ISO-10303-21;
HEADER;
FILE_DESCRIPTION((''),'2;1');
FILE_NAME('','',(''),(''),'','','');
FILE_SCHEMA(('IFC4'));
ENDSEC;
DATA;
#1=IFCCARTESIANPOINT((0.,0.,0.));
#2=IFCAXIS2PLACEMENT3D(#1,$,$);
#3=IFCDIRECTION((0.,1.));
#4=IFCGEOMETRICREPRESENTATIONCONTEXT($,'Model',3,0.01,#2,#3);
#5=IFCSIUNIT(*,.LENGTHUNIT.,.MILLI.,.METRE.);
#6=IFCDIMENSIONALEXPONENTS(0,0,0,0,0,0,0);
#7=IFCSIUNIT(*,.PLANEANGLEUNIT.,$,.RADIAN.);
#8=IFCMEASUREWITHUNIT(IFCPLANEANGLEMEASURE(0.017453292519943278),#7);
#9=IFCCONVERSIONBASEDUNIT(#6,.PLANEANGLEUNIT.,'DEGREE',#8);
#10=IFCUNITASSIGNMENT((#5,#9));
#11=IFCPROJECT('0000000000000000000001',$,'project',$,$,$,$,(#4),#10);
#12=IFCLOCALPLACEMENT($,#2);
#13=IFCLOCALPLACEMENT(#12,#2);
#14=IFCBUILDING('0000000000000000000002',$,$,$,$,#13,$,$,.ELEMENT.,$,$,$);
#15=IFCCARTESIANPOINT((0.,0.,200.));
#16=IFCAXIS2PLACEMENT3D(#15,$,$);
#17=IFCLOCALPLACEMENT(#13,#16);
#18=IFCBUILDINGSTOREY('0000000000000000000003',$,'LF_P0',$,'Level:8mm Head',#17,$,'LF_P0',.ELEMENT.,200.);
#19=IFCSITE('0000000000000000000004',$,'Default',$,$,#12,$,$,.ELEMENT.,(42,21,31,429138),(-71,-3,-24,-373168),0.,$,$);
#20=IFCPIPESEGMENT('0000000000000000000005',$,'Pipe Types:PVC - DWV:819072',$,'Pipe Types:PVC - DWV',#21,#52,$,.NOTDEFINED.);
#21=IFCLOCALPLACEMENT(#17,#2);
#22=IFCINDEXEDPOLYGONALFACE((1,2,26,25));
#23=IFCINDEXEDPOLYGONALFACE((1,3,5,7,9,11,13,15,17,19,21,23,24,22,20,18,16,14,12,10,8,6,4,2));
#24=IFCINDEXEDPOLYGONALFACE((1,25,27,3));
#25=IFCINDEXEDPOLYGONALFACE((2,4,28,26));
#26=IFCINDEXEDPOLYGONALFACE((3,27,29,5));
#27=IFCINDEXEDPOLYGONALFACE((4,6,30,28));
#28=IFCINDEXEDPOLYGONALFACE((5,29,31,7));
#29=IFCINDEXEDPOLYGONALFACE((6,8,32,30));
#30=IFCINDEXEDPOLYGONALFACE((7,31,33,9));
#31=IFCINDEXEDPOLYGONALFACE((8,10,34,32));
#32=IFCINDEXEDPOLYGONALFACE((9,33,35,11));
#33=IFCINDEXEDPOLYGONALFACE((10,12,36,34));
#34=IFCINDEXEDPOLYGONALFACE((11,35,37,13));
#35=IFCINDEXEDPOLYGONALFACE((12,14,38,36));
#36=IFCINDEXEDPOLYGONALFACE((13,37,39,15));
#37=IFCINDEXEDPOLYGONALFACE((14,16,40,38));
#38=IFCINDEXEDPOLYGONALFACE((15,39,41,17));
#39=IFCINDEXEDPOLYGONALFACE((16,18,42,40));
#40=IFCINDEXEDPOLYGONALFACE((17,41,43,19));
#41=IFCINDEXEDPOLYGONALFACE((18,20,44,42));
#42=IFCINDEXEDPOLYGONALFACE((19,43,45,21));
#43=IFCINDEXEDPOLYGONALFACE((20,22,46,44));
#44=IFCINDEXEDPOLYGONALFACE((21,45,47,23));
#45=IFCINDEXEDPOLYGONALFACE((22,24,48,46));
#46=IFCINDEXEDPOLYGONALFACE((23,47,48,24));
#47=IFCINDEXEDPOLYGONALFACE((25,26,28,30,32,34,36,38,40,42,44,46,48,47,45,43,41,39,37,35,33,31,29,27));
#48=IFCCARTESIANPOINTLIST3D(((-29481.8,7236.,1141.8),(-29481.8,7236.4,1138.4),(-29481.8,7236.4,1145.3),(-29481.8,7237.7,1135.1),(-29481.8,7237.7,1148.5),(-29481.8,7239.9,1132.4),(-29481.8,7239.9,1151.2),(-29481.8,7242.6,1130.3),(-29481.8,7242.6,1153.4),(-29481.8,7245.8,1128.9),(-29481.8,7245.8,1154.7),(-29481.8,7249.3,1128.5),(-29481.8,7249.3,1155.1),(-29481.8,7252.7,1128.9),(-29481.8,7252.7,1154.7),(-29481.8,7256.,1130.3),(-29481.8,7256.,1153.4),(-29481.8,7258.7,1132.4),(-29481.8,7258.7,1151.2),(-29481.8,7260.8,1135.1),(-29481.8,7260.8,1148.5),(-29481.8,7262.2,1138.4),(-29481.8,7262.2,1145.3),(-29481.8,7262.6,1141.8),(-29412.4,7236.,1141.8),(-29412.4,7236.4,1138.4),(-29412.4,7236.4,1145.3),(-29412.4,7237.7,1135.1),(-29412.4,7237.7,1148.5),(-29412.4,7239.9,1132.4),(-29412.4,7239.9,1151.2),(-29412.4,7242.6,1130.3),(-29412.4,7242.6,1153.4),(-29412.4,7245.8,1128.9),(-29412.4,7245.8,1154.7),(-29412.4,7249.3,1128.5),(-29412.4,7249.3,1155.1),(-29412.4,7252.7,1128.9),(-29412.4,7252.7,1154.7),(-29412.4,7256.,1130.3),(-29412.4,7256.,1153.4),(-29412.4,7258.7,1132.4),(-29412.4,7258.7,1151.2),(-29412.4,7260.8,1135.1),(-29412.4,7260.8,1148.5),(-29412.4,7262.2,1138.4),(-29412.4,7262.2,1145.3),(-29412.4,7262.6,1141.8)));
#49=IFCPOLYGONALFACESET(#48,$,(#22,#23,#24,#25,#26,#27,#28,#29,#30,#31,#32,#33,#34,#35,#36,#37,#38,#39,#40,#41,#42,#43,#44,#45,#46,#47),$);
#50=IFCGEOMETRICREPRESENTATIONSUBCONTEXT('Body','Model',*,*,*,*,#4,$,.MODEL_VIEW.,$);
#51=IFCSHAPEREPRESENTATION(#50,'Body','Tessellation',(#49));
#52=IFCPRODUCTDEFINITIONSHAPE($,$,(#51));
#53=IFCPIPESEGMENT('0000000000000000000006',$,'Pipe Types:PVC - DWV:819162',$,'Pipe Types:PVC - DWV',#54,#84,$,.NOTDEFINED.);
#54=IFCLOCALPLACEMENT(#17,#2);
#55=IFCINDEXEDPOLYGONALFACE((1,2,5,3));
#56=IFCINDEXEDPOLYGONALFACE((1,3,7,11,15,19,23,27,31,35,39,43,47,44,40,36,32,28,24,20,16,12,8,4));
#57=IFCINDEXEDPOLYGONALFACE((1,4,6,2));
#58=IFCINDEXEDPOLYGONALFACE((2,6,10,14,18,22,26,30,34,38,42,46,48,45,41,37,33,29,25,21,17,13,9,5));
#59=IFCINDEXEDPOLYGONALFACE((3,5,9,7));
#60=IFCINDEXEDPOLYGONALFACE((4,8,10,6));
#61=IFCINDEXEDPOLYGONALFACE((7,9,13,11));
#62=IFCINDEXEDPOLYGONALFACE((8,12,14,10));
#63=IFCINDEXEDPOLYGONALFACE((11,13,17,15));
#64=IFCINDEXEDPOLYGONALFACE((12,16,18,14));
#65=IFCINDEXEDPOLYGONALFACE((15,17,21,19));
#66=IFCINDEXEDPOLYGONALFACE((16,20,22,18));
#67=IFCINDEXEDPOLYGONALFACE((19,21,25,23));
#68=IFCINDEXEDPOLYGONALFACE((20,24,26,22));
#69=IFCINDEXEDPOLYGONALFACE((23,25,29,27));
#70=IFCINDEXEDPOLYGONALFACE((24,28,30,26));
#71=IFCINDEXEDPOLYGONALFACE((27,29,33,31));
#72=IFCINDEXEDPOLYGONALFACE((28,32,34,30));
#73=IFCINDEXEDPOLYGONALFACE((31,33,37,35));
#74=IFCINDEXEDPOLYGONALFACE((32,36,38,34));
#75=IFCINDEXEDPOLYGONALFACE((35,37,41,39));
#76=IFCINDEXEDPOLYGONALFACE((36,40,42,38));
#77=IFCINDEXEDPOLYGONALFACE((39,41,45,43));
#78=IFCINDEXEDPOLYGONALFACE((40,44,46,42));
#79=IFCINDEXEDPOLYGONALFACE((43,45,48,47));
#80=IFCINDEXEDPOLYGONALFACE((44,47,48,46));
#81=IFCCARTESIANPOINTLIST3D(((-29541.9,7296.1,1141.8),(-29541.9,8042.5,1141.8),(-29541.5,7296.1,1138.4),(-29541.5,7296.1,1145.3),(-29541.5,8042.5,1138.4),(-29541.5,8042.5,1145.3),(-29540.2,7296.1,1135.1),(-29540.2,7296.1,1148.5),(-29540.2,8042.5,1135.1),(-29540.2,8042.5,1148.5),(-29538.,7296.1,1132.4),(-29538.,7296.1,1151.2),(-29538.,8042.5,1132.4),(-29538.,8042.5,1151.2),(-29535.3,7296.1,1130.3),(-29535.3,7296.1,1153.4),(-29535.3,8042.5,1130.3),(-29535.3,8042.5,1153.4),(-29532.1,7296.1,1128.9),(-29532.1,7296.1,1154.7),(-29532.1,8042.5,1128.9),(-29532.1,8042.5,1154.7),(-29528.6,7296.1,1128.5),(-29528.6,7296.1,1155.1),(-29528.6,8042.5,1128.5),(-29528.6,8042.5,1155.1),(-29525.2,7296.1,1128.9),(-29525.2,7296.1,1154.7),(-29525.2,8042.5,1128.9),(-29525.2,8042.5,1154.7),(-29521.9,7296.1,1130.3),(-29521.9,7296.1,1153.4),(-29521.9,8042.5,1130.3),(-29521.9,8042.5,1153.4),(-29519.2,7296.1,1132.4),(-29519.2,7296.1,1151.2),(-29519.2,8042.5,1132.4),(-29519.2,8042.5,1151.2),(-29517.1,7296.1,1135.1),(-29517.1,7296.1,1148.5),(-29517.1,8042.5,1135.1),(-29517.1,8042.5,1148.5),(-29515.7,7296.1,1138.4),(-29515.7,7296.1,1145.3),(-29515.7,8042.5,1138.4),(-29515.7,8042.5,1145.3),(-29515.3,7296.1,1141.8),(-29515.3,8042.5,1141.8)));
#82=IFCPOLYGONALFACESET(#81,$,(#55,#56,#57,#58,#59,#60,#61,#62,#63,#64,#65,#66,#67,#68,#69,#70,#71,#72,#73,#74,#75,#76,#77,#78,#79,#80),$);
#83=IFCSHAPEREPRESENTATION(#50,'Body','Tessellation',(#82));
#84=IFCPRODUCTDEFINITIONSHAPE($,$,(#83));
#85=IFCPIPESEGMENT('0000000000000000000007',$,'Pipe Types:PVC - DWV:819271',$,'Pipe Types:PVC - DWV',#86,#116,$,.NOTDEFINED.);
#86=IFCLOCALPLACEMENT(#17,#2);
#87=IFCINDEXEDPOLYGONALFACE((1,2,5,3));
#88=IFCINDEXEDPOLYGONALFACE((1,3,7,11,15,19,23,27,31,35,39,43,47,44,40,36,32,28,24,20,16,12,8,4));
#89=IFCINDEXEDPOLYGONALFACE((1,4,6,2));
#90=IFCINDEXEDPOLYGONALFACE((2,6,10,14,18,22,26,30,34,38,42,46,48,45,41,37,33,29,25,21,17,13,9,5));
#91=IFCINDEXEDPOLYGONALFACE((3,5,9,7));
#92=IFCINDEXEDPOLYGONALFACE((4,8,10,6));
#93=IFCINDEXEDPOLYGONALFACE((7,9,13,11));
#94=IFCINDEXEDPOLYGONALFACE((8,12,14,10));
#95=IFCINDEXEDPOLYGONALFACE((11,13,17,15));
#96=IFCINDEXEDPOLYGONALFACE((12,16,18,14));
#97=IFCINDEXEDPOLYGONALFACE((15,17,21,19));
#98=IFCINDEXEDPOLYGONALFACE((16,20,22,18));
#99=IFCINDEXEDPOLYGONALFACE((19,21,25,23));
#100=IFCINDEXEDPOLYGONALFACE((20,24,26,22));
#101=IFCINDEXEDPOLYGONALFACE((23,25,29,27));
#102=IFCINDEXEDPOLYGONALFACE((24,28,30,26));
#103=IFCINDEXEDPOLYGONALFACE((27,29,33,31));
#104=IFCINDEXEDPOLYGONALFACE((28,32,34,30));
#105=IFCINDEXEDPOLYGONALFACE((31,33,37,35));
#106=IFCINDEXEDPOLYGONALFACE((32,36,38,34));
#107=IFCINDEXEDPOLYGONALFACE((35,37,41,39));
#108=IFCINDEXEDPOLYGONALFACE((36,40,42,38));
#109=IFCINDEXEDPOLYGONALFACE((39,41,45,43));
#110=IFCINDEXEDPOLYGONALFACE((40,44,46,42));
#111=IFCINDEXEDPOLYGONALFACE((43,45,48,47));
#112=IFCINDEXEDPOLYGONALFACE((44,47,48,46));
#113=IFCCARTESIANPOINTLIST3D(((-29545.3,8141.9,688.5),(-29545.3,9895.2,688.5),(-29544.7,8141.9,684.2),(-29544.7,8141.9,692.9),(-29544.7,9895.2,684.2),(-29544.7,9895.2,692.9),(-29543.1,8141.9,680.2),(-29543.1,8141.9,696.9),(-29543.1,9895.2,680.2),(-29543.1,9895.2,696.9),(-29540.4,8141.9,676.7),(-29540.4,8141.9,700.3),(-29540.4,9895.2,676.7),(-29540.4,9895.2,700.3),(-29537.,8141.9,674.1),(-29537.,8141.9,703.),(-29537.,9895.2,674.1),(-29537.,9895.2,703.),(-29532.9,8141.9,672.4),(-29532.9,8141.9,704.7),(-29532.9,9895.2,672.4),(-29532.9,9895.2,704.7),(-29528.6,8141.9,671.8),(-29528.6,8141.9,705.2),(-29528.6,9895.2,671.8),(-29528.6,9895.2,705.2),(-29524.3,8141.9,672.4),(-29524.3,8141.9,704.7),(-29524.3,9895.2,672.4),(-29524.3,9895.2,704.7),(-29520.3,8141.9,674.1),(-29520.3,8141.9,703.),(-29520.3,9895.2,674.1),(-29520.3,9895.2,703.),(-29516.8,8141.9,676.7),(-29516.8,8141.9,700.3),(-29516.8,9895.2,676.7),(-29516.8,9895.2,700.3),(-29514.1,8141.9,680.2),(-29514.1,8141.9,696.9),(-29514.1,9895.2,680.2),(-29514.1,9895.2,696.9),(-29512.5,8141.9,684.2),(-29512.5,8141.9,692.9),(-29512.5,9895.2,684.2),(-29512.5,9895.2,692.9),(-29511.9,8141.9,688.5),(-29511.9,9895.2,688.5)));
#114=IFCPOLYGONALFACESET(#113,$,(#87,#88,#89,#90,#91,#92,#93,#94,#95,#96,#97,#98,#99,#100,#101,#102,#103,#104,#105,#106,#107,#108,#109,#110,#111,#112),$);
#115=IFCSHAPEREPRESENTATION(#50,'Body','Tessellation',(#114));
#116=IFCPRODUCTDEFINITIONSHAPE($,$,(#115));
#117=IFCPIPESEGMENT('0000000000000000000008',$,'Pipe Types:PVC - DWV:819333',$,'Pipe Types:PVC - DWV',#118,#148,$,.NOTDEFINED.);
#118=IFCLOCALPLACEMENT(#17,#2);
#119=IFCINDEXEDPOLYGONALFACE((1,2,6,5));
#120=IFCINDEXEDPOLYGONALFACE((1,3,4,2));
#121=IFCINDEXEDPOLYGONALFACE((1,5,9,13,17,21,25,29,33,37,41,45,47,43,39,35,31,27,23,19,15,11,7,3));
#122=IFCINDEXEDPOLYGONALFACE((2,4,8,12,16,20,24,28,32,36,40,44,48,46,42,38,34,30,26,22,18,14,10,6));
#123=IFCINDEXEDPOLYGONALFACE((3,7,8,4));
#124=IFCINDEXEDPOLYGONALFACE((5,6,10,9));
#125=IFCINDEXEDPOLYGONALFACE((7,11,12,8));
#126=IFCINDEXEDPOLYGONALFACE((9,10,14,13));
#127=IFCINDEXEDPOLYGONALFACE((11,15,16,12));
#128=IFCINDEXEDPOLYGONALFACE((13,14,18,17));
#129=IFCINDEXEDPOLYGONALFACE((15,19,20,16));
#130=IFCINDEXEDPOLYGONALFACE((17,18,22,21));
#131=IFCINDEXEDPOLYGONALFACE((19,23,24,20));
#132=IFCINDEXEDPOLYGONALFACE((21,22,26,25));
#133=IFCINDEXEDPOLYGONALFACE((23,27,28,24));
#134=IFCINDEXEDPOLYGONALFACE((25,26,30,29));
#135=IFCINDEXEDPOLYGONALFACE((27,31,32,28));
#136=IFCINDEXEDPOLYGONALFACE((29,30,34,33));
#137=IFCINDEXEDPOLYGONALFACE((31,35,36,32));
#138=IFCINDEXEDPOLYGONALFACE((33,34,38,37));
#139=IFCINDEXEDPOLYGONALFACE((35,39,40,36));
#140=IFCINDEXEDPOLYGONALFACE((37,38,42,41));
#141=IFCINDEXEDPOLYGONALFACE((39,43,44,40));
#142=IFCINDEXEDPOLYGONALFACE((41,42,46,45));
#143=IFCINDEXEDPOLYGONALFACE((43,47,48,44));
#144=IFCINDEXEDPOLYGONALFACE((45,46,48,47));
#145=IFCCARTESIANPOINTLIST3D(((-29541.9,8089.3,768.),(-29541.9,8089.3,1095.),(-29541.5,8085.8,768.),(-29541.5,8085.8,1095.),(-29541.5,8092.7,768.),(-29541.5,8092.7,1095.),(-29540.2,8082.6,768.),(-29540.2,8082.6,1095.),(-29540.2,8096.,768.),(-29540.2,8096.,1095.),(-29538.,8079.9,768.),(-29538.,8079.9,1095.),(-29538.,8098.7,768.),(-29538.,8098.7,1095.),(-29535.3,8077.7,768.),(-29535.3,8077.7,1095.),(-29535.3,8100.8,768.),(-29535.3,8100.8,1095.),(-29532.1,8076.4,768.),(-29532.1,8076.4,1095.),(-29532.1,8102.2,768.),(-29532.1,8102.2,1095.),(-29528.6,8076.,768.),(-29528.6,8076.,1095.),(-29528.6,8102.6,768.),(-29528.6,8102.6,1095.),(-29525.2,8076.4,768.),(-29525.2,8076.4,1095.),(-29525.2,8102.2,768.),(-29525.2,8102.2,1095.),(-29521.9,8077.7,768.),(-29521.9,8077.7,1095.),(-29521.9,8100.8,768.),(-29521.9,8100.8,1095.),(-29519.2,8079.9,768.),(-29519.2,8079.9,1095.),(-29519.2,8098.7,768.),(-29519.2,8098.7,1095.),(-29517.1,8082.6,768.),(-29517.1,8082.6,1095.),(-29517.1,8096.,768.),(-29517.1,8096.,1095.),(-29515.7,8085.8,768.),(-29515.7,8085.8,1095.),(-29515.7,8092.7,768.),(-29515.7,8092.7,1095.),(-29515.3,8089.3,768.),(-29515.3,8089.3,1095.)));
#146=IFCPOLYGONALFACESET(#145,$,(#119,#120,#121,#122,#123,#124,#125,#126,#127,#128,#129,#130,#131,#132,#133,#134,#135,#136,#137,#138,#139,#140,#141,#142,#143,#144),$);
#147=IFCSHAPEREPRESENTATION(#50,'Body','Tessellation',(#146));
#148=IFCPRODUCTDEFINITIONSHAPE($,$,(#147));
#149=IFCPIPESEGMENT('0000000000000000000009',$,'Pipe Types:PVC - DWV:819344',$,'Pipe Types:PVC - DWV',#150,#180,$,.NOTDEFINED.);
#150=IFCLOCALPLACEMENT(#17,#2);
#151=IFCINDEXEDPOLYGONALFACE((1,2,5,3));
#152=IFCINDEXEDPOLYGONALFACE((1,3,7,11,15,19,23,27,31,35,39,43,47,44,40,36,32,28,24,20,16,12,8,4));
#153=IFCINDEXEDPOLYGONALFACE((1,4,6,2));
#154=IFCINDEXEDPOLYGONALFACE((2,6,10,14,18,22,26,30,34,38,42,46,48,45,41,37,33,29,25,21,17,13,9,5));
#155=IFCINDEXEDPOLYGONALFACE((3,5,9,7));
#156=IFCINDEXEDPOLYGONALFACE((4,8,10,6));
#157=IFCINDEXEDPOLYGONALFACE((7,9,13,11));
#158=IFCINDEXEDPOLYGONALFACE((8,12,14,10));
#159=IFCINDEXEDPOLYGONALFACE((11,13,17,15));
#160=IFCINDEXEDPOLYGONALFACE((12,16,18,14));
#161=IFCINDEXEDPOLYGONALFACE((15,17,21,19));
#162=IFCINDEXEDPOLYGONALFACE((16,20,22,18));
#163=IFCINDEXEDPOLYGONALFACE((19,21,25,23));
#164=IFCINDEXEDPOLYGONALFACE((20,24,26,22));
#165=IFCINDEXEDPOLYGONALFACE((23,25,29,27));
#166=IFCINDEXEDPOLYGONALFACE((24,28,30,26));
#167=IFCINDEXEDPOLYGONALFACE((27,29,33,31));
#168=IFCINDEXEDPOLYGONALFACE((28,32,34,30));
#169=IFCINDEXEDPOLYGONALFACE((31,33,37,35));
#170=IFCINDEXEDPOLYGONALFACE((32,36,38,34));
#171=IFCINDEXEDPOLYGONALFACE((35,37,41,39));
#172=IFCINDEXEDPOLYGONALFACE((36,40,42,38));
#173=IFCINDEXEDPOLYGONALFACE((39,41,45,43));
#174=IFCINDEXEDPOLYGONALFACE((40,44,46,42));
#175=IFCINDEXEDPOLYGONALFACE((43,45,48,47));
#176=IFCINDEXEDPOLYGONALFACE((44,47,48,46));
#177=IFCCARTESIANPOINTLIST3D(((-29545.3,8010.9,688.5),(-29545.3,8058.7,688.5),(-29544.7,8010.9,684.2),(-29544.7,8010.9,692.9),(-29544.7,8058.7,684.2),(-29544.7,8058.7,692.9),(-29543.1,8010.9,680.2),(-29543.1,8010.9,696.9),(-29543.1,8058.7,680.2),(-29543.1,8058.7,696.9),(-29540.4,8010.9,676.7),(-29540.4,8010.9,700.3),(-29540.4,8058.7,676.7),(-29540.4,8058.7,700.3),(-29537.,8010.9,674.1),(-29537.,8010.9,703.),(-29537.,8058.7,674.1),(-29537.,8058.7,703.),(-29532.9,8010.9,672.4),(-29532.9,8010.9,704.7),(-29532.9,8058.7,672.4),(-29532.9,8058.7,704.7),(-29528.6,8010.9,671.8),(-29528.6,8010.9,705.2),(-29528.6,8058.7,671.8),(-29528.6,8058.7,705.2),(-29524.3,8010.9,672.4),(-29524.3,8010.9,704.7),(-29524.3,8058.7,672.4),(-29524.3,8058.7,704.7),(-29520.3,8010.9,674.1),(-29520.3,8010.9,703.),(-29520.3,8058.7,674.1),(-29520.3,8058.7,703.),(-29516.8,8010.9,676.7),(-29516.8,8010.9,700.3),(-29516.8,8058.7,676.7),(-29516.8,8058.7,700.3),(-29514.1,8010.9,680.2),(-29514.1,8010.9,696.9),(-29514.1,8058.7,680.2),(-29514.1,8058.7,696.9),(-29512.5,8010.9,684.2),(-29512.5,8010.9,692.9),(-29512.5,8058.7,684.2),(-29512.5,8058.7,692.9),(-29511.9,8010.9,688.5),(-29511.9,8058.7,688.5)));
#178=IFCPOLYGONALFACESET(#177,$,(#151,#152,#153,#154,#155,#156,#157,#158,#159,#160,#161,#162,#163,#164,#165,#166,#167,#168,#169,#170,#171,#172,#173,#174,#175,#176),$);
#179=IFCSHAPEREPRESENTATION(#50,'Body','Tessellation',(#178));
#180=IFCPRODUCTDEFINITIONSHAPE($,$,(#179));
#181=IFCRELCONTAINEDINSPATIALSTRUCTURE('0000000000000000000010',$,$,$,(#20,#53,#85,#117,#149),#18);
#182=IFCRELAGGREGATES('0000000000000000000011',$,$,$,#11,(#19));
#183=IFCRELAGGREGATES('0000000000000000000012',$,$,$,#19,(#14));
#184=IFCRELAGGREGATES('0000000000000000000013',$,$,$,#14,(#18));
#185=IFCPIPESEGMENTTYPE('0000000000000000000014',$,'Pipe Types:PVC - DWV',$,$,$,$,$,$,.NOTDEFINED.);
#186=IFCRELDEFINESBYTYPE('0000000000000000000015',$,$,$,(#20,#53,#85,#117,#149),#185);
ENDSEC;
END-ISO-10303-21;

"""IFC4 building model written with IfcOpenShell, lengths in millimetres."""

from ifc_helpers import new_model, entity, si_unit, converted_unit, direction, frame, origin, place, context, subcontext, project, spatial, arc, indexed_curve, outline, extrude, type_object, element, save


model = new_model("IFC4")

# Units and contexts
model_context = context("Model", 3, precision=0.01, world=origin(), true_north=direction((0.0, 1.0)))
body_context = subcontext(model_context, "Body", "Model", "MODEL_VIEW")
ifc_project = project(units=[si_unit("LENGTHUNIT", "METRE", prefix="MILLI"), converted_unit("PLANEANGLEUNIT", "DEGREE", entity("IfcPlaneAngleMeasure", 0.017453292519943278), si_unit("PLANEANGLEUNIT", "RADIAN"), dimensions=[0, 0, 0, 0, 0, 0, 0])], contexts=[model_context])

# Site, building, storey
site_placement = place(None, origin())
site = spatial("IfcSite", under=ifc_project, at=site_placement, Name="Default", CompositionType="ELEMENT", RefLatitude=(42, 21, 31, 429138), RefLongitude=(-71, -3, -24, -373168), RefElevation=0.0)
building_placement = place(site_placement, origin())
building = spatial("IfcBuilding", under=site, at=building_placement, CompositionType="ELEMENT")
storey_placement = place(building_placement, frame((0.0, 0.0, 200.0)))
storey = spatial("IfcBuildingStorey", under=building, at=storey_placement, Name="LF_P0", ObjectType="Level:8mm Head", LongName="LF_P0", CompositionType="ELEMENT", Elevation=200.0)

# Pipe segments
pipe_segment_type_1 = type_object("IfcPipeSegmentType", Name="Pipe Types:PVC - DWV", PredefinedType="NOTDEFINED")
pipe_segment_1_placement = place(storey_placement, origin())
element("IfcPipeSegment", 1, at=pipe_segment_1_placement, inside=storey, type_object=pipe_segment_type_1, Name="Pipe Types:PVC - DWV:819072", ObjectType="Pipe Types:PVC - DWV", PredefinedType="NOTDEFINED", context=body_context, shape_type="SweptSolid", body=[
    extrude(outline(indexed_curve([(13.3, 0.0), (9.4, 9.4), (0.0, 13.3), (-9.4, 9.4), (-13.3, 0.0), (-9.4, -9.4), (0.0, -13.3), (9.4, -9.4)], segments=[arc(1, 2, 3), arc(3, 4, 5), arc(5, 6, 7), arc(7, 8, 1)], self_intersect=False)), frame((-29481.8, 7249.3, 1141.8), z_axis=(1.0, 0.0, 0.0), x_axis=(0.0, 1.0, 0.0)), (0.0, 0.0, 1.0), 69.4),
])
pipe_segment_2_placement = place(storey_placement, origin())
element("IfcPipeSegment", 2, at=pipe_segment_2_placement, inside=storey, type_object=pipe_segment_type_1, Name="Pipe Types:PVC - DWV:819162", ObjectType="Pipe Types:PVC - DWV", PredefinedType="NOTDEFINED", context=body_context, shape_type="SweptSolid", body=[
    extrude(outline(indexed_curve([(13.3, 0.0), (9.4, 9.4), (0.0, 13.3), (-9.4, 9.4), (-13.3, 0.0), (-9.4, -9.4), (0.0, -13.3), (9.4, -9.4)], segments=[arc(1, 2, 3), arc(3, 4, 5), arc(5, 6, 7), arc(7, 8, 1)], self_intersect=False)), frame((-29528.6, 7296.1, 1141.8), z_axis=(0.0, 1.0, 0.0), x_axis=(1.0, 0.0, 0.0)), (0.0, 0.0, 1.0), 746.4),
])
pipe_segment_3_placement = place(storey_placement, origin())
element("IfcPipeSegment", 3, at=pipe_segment_3_placement, inside=storey, type_object=pipe_segment_type_1, Name="Pipe Types:PVC - DWV:819271", ObjectType="Pipe Types:PVC - DWV", PredefinedType="NOTDEFINED", context=body_context, shape_type="SweptSolid", body=[
    extrude(outline(indexed_curve([(16.7, 0.0), (11.8, 11.8), (0.0, 16.7), (-11.8, 11.8), (-16.7, 0.0), (-11.8, -11.8), (0.0, -16.7), (11.8, -11.8)], segments=[arc(1, 2, 3), arc(3, 4, 5), arc(5, 6, 7), arc(7, 8, 1)], self_intersect=False)), frame((-29528.6, 8141.9, 688.5), z_axis=(0.0, 1.0, 0.0), x_axis=(1.0, 0.0, 0.0)), (0.0, 0.0, 1.0), 1753.3),
])
pipe_segment_4_placement = place(storey_placement, origin())
element("IfcPipeSegment", 4, at=pipe_segment_4_placement, inside=storey, type_object=pipe_segment_type_1, Name="Pipe Types:PVC - DWV:819333", ObjectType="Pipe Types:PVC - DWV", PredefinedType="NOTDEFINED", context=body_context, shape_type="SweptSolid", body=[
    extrude(outline(indexed_curve([(13.3, 0.0), (9.4, 9.4), (0.0, 13.3), (-9.4, 9.4), (-13.3, 0.0), (-9.4, -9.4), (0.0, -13.3), (9.4, -9.4)], segments=[arc(1, 2, 3), arc(3, 4, 5), arc(5, 6, 7), arc(7, 8, 1)], self_intersect=False)), frame((-29528.6, 8089.3, 768.0), z_axis=(0.0, 0.0, 1.0), x_axis=(-1.0, 0.0, 0.0)), (0.0, 0.0, 1.0), 327.0),
])
pipe_segment_5_placement = place(storey_placement, origin())
element("IfcPipeSegment", 5, at=pipe_segment_5_placement, inside=storey, type_object=pipe_segment_type_1, Name="Pipe Types:PVC - DWV:819344", ObjectType="Pipe Types:PVC - DWV", PredefinedType="NOTDEFINED", context=body_context, shape_type="SweptSolid", body=[
    extrude(outline(indexed_curve([(16.7, 0.0), (11.8, 11.8), (0.0, 16.7), (-11.8, 11.8), (-16.7, 0.0), (-11.8, -11.8), (0.0, -16.7), (11.8, -11.8)], segments=[arc(1, 2, 3), arc(3, 4, 5), arc(5, 6, 7), arc(7, 8, 1)], self_intersect=False)), frame((-29528.6, 8010.9, 688.5), z_axis=(0.0, 1.0, 0.0), x_axis=(1.0, 0.0, 0.0)), (0.0, 0.0, 1.0), 47.7),
])

save(model, "model.ifc")
